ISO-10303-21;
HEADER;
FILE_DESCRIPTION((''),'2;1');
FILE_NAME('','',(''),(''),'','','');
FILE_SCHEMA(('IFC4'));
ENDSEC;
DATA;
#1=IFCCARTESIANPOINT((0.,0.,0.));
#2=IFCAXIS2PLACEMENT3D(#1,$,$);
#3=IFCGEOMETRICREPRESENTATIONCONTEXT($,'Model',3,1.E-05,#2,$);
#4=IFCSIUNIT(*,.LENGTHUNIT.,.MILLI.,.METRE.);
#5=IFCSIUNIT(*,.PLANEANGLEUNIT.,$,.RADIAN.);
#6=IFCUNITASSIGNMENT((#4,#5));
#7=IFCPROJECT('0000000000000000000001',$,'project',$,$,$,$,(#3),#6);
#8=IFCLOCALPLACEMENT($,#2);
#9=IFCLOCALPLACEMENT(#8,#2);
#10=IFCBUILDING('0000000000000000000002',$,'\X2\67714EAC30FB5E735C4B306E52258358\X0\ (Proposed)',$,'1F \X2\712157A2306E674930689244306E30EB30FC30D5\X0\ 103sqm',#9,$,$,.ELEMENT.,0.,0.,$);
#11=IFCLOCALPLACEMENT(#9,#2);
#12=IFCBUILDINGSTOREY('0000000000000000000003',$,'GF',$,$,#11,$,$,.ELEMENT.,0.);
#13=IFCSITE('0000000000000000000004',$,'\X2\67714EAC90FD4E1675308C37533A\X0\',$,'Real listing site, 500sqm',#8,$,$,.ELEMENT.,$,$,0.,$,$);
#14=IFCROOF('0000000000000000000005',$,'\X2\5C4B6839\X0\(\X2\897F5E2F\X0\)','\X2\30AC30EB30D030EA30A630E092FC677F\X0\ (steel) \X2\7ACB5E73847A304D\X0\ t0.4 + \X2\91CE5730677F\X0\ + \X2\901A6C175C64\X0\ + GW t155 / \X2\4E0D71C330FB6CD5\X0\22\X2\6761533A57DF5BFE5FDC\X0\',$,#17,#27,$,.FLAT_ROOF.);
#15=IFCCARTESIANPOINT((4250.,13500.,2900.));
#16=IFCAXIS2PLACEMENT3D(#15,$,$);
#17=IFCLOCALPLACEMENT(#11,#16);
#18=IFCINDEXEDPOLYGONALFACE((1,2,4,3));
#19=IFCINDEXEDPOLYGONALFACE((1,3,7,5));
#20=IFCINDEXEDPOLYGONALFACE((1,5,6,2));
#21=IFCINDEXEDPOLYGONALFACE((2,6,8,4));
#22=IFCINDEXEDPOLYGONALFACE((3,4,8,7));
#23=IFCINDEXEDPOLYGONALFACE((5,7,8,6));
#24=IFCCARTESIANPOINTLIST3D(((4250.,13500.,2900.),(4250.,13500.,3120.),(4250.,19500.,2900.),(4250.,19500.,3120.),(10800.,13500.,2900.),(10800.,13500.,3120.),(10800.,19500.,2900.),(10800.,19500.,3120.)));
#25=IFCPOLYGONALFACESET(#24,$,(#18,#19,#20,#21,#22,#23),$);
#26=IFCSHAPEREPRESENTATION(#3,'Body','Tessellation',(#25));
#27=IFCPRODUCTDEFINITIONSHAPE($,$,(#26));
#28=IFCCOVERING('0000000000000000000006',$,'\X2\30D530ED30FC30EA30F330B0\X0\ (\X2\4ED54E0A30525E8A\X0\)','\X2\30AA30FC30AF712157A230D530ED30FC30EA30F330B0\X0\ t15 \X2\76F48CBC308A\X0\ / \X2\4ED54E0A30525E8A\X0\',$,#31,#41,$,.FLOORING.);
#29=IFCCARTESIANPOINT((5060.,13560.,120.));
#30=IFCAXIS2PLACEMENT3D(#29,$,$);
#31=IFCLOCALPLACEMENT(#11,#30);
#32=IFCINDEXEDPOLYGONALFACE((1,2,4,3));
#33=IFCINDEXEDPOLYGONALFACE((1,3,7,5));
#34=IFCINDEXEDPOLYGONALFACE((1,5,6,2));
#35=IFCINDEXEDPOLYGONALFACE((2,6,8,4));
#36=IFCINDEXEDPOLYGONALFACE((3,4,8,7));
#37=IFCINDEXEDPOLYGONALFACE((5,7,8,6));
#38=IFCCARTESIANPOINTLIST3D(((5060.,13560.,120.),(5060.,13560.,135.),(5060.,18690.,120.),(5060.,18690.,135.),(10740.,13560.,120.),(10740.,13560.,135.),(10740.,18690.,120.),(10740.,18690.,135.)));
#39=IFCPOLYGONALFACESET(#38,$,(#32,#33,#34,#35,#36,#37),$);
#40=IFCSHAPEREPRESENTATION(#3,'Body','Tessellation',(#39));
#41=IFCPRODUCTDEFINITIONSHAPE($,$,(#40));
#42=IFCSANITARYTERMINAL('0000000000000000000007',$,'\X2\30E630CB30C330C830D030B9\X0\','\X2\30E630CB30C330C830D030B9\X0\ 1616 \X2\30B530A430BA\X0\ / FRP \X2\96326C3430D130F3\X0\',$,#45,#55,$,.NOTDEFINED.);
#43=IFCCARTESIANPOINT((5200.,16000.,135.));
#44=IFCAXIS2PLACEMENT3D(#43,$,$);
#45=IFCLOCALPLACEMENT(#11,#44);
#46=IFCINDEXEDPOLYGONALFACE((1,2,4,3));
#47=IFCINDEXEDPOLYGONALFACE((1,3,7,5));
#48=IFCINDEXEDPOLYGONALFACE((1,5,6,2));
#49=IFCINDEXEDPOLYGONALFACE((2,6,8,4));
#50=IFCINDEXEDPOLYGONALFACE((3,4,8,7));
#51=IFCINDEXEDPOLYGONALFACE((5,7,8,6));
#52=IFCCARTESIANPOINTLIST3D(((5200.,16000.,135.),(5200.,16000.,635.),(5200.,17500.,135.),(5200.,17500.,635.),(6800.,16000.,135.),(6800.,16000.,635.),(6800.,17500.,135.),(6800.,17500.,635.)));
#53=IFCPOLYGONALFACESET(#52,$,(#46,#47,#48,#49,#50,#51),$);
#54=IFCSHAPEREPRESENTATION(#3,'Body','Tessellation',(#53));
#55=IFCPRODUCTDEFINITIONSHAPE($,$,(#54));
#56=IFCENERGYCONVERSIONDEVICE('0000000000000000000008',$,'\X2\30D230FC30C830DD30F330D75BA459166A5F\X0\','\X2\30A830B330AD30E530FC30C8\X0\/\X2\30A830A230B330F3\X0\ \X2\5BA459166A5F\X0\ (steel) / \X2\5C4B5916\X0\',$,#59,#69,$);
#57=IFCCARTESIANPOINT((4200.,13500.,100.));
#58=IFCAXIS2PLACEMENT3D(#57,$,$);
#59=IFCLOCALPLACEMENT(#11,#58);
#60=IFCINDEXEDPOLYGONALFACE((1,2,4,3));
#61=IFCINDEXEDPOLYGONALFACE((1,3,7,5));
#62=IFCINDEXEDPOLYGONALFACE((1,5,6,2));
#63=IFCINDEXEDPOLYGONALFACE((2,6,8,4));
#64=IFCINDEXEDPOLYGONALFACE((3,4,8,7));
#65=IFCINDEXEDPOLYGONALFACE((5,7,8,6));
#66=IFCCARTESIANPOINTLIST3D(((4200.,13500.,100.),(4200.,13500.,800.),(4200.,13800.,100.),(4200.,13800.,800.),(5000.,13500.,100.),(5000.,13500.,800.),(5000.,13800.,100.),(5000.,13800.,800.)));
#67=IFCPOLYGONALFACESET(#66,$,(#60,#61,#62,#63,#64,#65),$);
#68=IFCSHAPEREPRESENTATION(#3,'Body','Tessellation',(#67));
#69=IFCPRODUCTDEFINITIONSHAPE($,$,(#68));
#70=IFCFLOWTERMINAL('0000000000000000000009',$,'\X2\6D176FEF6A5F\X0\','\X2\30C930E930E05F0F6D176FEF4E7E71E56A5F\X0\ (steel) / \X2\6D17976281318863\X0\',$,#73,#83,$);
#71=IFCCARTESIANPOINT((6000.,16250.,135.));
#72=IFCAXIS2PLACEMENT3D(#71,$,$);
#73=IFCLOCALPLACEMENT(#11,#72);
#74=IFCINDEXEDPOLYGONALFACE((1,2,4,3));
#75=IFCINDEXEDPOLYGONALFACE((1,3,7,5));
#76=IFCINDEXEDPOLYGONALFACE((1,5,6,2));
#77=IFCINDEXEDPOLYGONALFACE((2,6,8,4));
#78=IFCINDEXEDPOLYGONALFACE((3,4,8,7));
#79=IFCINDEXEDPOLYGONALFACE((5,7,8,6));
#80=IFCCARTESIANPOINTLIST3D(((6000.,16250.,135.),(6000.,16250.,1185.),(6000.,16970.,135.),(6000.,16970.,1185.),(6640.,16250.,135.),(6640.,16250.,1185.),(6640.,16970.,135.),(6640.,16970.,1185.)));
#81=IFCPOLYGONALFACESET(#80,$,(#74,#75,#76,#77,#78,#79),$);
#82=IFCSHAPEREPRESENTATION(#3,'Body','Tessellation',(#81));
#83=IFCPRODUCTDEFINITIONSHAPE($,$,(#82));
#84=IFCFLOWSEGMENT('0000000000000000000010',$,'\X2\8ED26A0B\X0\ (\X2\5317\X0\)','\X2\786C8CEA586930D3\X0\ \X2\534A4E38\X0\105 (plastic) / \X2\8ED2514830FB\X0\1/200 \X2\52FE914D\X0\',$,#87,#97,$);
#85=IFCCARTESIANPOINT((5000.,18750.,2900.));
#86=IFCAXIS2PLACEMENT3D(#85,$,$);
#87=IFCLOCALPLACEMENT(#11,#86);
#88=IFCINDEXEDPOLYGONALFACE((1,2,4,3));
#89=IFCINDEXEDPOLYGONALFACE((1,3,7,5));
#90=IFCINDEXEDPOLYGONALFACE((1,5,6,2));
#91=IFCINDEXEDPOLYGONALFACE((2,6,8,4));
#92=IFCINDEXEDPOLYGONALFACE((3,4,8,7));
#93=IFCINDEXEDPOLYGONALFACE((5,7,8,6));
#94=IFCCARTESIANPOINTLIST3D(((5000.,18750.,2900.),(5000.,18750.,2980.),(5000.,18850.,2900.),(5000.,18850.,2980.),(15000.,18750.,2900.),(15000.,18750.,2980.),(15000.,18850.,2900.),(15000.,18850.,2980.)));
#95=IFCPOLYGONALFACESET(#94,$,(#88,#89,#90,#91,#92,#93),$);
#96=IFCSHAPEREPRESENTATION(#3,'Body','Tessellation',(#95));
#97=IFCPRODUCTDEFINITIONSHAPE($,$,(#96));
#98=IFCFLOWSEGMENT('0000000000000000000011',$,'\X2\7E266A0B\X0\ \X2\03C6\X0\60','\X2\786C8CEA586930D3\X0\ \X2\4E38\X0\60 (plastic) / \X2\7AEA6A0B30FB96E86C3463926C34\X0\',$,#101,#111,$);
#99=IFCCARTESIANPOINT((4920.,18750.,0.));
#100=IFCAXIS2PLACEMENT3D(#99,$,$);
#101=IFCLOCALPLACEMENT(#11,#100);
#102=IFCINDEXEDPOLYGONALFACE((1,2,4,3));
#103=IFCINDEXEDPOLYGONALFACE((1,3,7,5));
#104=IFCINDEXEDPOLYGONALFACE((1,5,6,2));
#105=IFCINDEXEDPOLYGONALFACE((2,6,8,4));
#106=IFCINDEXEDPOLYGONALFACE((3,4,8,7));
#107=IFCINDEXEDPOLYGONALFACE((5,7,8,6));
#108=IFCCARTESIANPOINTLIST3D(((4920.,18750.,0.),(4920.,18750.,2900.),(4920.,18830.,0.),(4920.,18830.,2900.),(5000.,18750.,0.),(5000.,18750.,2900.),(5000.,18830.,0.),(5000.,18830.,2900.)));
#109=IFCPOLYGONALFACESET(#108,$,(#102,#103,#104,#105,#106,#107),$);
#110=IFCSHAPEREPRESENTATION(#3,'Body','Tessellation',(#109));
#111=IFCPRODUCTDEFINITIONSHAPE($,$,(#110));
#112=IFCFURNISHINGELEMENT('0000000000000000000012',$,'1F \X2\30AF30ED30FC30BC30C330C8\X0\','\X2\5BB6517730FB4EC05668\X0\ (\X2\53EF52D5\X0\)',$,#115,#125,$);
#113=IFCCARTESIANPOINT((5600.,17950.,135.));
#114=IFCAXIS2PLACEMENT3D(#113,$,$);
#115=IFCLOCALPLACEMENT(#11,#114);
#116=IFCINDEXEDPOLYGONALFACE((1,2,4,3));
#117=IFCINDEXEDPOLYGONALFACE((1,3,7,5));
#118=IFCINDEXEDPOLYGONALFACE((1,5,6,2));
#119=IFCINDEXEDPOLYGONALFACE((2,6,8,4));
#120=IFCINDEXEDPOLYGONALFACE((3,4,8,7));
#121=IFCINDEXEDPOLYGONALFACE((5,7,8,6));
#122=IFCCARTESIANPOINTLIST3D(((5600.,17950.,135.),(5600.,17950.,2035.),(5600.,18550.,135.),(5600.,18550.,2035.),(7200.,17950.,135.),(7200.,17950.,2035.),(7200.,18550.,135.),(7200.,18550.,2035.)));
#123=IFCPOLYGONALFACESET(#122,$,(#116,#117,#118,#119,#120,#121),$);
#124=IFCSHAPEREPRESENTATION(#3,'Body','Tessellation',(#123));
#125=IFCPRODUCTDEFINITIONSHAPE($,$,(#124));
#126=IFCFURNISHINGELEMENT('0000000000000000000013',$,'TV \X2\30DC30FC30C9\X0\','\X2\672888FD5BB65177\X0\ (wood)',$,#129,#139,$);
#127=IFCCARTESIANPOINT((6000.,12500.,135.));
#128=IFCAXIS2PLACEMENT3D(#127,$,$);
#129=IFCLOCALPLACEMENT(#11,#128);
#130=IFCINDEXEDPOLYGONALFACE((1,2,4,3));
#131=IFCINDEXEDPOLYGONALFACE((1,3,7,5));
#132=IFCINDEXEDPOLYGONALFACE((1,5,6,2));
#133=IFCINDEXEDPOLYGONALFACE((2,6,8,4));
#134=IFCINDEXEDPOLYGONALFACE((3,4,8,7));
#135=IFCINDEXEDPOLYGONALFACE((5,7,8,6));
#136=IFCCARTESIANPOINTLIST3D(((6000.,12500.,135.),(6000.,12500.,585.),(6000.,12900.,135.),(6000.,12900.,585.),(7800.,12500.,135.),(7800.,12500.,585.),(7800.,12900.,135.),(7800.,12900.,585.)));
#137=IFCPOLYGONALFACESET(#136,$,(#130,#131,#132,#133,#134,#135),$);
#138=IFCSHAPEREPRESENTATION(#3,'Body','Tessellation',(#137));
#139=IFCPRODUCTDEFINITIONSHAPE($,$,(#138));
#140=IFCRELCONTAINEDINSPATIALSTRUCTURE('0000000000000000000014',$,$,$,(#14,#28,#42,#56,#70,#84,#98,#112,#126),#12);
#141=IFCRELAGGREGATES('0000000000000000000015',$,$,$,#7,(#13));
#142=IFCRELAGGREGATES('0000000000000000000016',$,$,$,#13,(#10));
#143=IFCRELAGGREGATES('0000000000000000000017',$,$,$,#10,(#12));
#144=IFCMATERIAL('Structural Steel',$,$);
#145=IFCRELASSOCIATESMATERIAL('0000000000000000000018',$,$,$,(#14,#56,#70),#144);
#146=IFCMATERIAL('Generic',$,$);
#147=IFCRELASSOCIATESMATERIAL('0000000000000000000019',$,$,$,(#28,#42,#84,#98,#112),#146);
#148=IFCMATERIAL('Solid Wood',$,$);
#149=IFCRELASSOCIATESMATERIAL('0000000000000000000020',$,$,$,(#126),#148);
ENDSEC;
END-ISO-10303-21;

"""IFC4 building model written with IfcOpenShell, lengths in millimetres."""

from ifc_helpers import new_model, si_unit, frame, frame_2d, origin, place, context, project, spatial, rectangle, extrude, material, element, save


model = new_model("IFC4")

# Units and contexts
model_context = context("Model", 3, precision=1e-05, world=origin())
ifc_project = project(units=[si_unit("LENGTHUNIT", "METRE", prefix="MILLI"), si_unit("PLANEANGLEUNIT", "RADIAN")], contexts=[model_context])

# Site, building, storey
site_placement = place(None, origin())
site = spatial("IfcSite", under=ifc_project, at=site_placement, Name="東京都世田谷区", ObjectType="Real listing site, 500sqm", CompositionType="ELEMENT", RefElevation=0.0)
building_placement = place(site_placement, origin())
building = spatial("IfcBuilding", under=site, at=building_placement, Name="東京・平屋の別荘 (Proposed)", ObjectType="1F 無垢の杉と鉄のルーフ 103sqm", CompositionType="ELEMENT", ElevationOfRefHeight=0.0, ElevationOfTerrain=0.0)
storey_placement = place(building_placement, origin())
storey = spatial("IfcBuildingStorey", under=building, at=storey_placement, Name="GF", CompositionType="ELEMENT", Elevation=0.0)

# Shared definitions
ifc_material_1 = material(Name="Solid Wood")

# Roof
ifc_material_2 = material(Name="Structural Steel")
roof_placement = place(storey_placement, frame((4250.0, 13500.0, 2900.0)))
element("IfcRoof", 1, at=roof_placement, inside=storey, material=ifc_material_2, Name="屋根(西帯)", Description="ガルバリウム鋼板 (steel) 立平葺き t0.4 + 野地板 + 通気層 + GW t155 / 不燃・法22条区域対応", PredefinedType="FLAT_ROOF", context=model_context, shape_type="SweptSolid", body=[
    extrude(rectangle(XDim=6550.0, YDim=6000.0, at=frame_2d((3275.0, 3000.0))), frame((4250.0, 13500.0, 2900.0)), (0.0, 0.0, 1.0), 220.0),
])

# Covering
ifc_material_3 = material(Name="Generic")
covering_placement = place(storey_placement, frame((5060.0, 13560.0, 120.0)))
element("IfcCovering", 2, at=covering_placement, inside=storey, material=ifc_material_3, Name="フローリング (仕上げ床)", Description="オーク無垢フローリング t15 直貼り / 仕上げ床", PredefinedType="FLOORING", context=model_context, shape_type="SweptSolid", body=[
    extrude(rectangle(XDim=5680.0, YDim=5130.0, at=frame_2d((2840.0, 2565.0))), frame((5060.0, 13560.0, 120.0)), (0.0, 0.0, 1.0), 15.0),
])

# Sanitary terminal
sanitary_terminal_placement = place(storey_placement, frame((5200.0, 16000.0, 135.0)))
element("IfcSanitaryTerminal", 3, at=sanitary_terminal_placement, inside=storey, material=ifc_material_3, Name="ユニットバス", Description="ユニットバス 1616 サイズ / FRP 防水パン", PredefinedType="NOTDEFINED", context=model_context, shape_type="SweptSolid", body=[
    extrude(rectangle(XDim=1600.0, YDim=1500.0, at=frame_2d((800.0, 750.0))), frame((5200.0, 16000.0, 135.0)), (0.0, 0.0, 1.0), 500.0),
])

# Energy conversion device
energy_conversion_device_placement = place(storey_placement, frame((4200.0, 13500.0, 100.0)))
element("IfcEnergyConversionDevice", 4, at=energy_conversion_device_placement, inside=storey, material=ifc_material_2, Name="ヒートポンプ室外機", Description="エコキュート/エアコン 室外機 (steel) / 屋外", context=model_context, shape_type="SweptSolid", body=[
    extrude(rectangle(XDim=800.0, YDim=300.0, at=frame_2d((400.0, 150.0))), frame((4200.0, 13500.0, 100.0)), (0.0, 0.0, 1.0), 700.0),
])

# Flow terminal
flow_terminal_placement = place(storey_placement, frame((6000.0, 16250.0, 135.0)))
element("IfcFlowTerminal", 5, at=flow_terminal_placement, inside=storey, material=ifc_material_2, Name="洗濯機", Description="ドラム式洗濯乾燥機 (steel) / 洗面脱衣", context=model_context, shape_type="SweptSolid", body=[
    extrude(rectangle(XDim=640.0, YDim=720.0, at=frame_2d((320.0, 360.0))), frame((6000.0, 16250.0, 135.0)), (0.0, 0.0, 1.0), 1050.0),
])

# Flow segments
flow_segment_1_placement = place(storey_placement, frame((5000.0, 18750.0, 2900.0)))
element("IfcFlowSegment", 6, at=flow_segment_1_placement, inside=storey, material=ifc_material_3, Name="軒樋 (北)", Description="硬質塩ビ 半丸105 (plastic) / 軒先・1/200 勾配", context=model_context, shape_type="SweptSolid", body=[
    extrude(rectangle(XDim=10000.0, YDim=100.0, at=frame_2d((5000.0, 50.0))), frame((5000.0, 18750.0, 2900.0)), (0.0, 0.0, 1.0), 80.0),
])
flow_segment_2_placement = place(storey_placement, frame((4920.0, 18750.0, 0.0)))
element("IfcFlowSegment", 7, at=flow_segment_2_placement, inside=storey, material=ifc_material_3, Name="縦樋 φ60", Description="硬質塩ビ 丸60 (plastic) / 竪樋・雨水排水", context=model_context, shape_type="SweptSolid", body=[
    extrude(rectangle(XDim=80.0, YDim=80.0, at=frame_2d((40.0, 40.0))), frame((4920.0, 18750.0, 0.0)), (0.0, 0.0, 1.0), 2900.0),
])

# Furnishing elements
furnishing_1_placement = place(storey_placement, frame((5600.0, 17950.0, 135.0)))
element("IfcFurnishingElement", 8, at=furnishing_1_placement, inside=storey, material=ifc_material_3, Name="1F クローゼット", Description="家具・什器 (可動)", context=model_context, shape_type="SweptSolid", body=[
    extrude(rectangle(XDim=1600.0, YDim=600.0, at=frame_2d((800.0, 300.0))), frame((5600.0, 17950.0, 135.0)), (0.0, 0.0, 1.0), 1900.0),
])
furnishing_2_placement = place(storey_placement, frame((6000.0, 12500.0, 135.0)))
element("IfcFurnishingElement", 9, at=furnishing_2_placement, inside=storey, material=ifc_material_1, Name="TV ボード", Description="木製家具 (wood)", context=model_context, shape_type="SweptSolid", body=[
    extrude(rectangle(XDim=1800.0, YDim=400.0, at=frame_2d((900.0, 200.0))), frame((6000.0, 12500.0, 135.0)), (0.0, 0.0, 1.0), 450.0),
])

save(model, "model.ifc")
